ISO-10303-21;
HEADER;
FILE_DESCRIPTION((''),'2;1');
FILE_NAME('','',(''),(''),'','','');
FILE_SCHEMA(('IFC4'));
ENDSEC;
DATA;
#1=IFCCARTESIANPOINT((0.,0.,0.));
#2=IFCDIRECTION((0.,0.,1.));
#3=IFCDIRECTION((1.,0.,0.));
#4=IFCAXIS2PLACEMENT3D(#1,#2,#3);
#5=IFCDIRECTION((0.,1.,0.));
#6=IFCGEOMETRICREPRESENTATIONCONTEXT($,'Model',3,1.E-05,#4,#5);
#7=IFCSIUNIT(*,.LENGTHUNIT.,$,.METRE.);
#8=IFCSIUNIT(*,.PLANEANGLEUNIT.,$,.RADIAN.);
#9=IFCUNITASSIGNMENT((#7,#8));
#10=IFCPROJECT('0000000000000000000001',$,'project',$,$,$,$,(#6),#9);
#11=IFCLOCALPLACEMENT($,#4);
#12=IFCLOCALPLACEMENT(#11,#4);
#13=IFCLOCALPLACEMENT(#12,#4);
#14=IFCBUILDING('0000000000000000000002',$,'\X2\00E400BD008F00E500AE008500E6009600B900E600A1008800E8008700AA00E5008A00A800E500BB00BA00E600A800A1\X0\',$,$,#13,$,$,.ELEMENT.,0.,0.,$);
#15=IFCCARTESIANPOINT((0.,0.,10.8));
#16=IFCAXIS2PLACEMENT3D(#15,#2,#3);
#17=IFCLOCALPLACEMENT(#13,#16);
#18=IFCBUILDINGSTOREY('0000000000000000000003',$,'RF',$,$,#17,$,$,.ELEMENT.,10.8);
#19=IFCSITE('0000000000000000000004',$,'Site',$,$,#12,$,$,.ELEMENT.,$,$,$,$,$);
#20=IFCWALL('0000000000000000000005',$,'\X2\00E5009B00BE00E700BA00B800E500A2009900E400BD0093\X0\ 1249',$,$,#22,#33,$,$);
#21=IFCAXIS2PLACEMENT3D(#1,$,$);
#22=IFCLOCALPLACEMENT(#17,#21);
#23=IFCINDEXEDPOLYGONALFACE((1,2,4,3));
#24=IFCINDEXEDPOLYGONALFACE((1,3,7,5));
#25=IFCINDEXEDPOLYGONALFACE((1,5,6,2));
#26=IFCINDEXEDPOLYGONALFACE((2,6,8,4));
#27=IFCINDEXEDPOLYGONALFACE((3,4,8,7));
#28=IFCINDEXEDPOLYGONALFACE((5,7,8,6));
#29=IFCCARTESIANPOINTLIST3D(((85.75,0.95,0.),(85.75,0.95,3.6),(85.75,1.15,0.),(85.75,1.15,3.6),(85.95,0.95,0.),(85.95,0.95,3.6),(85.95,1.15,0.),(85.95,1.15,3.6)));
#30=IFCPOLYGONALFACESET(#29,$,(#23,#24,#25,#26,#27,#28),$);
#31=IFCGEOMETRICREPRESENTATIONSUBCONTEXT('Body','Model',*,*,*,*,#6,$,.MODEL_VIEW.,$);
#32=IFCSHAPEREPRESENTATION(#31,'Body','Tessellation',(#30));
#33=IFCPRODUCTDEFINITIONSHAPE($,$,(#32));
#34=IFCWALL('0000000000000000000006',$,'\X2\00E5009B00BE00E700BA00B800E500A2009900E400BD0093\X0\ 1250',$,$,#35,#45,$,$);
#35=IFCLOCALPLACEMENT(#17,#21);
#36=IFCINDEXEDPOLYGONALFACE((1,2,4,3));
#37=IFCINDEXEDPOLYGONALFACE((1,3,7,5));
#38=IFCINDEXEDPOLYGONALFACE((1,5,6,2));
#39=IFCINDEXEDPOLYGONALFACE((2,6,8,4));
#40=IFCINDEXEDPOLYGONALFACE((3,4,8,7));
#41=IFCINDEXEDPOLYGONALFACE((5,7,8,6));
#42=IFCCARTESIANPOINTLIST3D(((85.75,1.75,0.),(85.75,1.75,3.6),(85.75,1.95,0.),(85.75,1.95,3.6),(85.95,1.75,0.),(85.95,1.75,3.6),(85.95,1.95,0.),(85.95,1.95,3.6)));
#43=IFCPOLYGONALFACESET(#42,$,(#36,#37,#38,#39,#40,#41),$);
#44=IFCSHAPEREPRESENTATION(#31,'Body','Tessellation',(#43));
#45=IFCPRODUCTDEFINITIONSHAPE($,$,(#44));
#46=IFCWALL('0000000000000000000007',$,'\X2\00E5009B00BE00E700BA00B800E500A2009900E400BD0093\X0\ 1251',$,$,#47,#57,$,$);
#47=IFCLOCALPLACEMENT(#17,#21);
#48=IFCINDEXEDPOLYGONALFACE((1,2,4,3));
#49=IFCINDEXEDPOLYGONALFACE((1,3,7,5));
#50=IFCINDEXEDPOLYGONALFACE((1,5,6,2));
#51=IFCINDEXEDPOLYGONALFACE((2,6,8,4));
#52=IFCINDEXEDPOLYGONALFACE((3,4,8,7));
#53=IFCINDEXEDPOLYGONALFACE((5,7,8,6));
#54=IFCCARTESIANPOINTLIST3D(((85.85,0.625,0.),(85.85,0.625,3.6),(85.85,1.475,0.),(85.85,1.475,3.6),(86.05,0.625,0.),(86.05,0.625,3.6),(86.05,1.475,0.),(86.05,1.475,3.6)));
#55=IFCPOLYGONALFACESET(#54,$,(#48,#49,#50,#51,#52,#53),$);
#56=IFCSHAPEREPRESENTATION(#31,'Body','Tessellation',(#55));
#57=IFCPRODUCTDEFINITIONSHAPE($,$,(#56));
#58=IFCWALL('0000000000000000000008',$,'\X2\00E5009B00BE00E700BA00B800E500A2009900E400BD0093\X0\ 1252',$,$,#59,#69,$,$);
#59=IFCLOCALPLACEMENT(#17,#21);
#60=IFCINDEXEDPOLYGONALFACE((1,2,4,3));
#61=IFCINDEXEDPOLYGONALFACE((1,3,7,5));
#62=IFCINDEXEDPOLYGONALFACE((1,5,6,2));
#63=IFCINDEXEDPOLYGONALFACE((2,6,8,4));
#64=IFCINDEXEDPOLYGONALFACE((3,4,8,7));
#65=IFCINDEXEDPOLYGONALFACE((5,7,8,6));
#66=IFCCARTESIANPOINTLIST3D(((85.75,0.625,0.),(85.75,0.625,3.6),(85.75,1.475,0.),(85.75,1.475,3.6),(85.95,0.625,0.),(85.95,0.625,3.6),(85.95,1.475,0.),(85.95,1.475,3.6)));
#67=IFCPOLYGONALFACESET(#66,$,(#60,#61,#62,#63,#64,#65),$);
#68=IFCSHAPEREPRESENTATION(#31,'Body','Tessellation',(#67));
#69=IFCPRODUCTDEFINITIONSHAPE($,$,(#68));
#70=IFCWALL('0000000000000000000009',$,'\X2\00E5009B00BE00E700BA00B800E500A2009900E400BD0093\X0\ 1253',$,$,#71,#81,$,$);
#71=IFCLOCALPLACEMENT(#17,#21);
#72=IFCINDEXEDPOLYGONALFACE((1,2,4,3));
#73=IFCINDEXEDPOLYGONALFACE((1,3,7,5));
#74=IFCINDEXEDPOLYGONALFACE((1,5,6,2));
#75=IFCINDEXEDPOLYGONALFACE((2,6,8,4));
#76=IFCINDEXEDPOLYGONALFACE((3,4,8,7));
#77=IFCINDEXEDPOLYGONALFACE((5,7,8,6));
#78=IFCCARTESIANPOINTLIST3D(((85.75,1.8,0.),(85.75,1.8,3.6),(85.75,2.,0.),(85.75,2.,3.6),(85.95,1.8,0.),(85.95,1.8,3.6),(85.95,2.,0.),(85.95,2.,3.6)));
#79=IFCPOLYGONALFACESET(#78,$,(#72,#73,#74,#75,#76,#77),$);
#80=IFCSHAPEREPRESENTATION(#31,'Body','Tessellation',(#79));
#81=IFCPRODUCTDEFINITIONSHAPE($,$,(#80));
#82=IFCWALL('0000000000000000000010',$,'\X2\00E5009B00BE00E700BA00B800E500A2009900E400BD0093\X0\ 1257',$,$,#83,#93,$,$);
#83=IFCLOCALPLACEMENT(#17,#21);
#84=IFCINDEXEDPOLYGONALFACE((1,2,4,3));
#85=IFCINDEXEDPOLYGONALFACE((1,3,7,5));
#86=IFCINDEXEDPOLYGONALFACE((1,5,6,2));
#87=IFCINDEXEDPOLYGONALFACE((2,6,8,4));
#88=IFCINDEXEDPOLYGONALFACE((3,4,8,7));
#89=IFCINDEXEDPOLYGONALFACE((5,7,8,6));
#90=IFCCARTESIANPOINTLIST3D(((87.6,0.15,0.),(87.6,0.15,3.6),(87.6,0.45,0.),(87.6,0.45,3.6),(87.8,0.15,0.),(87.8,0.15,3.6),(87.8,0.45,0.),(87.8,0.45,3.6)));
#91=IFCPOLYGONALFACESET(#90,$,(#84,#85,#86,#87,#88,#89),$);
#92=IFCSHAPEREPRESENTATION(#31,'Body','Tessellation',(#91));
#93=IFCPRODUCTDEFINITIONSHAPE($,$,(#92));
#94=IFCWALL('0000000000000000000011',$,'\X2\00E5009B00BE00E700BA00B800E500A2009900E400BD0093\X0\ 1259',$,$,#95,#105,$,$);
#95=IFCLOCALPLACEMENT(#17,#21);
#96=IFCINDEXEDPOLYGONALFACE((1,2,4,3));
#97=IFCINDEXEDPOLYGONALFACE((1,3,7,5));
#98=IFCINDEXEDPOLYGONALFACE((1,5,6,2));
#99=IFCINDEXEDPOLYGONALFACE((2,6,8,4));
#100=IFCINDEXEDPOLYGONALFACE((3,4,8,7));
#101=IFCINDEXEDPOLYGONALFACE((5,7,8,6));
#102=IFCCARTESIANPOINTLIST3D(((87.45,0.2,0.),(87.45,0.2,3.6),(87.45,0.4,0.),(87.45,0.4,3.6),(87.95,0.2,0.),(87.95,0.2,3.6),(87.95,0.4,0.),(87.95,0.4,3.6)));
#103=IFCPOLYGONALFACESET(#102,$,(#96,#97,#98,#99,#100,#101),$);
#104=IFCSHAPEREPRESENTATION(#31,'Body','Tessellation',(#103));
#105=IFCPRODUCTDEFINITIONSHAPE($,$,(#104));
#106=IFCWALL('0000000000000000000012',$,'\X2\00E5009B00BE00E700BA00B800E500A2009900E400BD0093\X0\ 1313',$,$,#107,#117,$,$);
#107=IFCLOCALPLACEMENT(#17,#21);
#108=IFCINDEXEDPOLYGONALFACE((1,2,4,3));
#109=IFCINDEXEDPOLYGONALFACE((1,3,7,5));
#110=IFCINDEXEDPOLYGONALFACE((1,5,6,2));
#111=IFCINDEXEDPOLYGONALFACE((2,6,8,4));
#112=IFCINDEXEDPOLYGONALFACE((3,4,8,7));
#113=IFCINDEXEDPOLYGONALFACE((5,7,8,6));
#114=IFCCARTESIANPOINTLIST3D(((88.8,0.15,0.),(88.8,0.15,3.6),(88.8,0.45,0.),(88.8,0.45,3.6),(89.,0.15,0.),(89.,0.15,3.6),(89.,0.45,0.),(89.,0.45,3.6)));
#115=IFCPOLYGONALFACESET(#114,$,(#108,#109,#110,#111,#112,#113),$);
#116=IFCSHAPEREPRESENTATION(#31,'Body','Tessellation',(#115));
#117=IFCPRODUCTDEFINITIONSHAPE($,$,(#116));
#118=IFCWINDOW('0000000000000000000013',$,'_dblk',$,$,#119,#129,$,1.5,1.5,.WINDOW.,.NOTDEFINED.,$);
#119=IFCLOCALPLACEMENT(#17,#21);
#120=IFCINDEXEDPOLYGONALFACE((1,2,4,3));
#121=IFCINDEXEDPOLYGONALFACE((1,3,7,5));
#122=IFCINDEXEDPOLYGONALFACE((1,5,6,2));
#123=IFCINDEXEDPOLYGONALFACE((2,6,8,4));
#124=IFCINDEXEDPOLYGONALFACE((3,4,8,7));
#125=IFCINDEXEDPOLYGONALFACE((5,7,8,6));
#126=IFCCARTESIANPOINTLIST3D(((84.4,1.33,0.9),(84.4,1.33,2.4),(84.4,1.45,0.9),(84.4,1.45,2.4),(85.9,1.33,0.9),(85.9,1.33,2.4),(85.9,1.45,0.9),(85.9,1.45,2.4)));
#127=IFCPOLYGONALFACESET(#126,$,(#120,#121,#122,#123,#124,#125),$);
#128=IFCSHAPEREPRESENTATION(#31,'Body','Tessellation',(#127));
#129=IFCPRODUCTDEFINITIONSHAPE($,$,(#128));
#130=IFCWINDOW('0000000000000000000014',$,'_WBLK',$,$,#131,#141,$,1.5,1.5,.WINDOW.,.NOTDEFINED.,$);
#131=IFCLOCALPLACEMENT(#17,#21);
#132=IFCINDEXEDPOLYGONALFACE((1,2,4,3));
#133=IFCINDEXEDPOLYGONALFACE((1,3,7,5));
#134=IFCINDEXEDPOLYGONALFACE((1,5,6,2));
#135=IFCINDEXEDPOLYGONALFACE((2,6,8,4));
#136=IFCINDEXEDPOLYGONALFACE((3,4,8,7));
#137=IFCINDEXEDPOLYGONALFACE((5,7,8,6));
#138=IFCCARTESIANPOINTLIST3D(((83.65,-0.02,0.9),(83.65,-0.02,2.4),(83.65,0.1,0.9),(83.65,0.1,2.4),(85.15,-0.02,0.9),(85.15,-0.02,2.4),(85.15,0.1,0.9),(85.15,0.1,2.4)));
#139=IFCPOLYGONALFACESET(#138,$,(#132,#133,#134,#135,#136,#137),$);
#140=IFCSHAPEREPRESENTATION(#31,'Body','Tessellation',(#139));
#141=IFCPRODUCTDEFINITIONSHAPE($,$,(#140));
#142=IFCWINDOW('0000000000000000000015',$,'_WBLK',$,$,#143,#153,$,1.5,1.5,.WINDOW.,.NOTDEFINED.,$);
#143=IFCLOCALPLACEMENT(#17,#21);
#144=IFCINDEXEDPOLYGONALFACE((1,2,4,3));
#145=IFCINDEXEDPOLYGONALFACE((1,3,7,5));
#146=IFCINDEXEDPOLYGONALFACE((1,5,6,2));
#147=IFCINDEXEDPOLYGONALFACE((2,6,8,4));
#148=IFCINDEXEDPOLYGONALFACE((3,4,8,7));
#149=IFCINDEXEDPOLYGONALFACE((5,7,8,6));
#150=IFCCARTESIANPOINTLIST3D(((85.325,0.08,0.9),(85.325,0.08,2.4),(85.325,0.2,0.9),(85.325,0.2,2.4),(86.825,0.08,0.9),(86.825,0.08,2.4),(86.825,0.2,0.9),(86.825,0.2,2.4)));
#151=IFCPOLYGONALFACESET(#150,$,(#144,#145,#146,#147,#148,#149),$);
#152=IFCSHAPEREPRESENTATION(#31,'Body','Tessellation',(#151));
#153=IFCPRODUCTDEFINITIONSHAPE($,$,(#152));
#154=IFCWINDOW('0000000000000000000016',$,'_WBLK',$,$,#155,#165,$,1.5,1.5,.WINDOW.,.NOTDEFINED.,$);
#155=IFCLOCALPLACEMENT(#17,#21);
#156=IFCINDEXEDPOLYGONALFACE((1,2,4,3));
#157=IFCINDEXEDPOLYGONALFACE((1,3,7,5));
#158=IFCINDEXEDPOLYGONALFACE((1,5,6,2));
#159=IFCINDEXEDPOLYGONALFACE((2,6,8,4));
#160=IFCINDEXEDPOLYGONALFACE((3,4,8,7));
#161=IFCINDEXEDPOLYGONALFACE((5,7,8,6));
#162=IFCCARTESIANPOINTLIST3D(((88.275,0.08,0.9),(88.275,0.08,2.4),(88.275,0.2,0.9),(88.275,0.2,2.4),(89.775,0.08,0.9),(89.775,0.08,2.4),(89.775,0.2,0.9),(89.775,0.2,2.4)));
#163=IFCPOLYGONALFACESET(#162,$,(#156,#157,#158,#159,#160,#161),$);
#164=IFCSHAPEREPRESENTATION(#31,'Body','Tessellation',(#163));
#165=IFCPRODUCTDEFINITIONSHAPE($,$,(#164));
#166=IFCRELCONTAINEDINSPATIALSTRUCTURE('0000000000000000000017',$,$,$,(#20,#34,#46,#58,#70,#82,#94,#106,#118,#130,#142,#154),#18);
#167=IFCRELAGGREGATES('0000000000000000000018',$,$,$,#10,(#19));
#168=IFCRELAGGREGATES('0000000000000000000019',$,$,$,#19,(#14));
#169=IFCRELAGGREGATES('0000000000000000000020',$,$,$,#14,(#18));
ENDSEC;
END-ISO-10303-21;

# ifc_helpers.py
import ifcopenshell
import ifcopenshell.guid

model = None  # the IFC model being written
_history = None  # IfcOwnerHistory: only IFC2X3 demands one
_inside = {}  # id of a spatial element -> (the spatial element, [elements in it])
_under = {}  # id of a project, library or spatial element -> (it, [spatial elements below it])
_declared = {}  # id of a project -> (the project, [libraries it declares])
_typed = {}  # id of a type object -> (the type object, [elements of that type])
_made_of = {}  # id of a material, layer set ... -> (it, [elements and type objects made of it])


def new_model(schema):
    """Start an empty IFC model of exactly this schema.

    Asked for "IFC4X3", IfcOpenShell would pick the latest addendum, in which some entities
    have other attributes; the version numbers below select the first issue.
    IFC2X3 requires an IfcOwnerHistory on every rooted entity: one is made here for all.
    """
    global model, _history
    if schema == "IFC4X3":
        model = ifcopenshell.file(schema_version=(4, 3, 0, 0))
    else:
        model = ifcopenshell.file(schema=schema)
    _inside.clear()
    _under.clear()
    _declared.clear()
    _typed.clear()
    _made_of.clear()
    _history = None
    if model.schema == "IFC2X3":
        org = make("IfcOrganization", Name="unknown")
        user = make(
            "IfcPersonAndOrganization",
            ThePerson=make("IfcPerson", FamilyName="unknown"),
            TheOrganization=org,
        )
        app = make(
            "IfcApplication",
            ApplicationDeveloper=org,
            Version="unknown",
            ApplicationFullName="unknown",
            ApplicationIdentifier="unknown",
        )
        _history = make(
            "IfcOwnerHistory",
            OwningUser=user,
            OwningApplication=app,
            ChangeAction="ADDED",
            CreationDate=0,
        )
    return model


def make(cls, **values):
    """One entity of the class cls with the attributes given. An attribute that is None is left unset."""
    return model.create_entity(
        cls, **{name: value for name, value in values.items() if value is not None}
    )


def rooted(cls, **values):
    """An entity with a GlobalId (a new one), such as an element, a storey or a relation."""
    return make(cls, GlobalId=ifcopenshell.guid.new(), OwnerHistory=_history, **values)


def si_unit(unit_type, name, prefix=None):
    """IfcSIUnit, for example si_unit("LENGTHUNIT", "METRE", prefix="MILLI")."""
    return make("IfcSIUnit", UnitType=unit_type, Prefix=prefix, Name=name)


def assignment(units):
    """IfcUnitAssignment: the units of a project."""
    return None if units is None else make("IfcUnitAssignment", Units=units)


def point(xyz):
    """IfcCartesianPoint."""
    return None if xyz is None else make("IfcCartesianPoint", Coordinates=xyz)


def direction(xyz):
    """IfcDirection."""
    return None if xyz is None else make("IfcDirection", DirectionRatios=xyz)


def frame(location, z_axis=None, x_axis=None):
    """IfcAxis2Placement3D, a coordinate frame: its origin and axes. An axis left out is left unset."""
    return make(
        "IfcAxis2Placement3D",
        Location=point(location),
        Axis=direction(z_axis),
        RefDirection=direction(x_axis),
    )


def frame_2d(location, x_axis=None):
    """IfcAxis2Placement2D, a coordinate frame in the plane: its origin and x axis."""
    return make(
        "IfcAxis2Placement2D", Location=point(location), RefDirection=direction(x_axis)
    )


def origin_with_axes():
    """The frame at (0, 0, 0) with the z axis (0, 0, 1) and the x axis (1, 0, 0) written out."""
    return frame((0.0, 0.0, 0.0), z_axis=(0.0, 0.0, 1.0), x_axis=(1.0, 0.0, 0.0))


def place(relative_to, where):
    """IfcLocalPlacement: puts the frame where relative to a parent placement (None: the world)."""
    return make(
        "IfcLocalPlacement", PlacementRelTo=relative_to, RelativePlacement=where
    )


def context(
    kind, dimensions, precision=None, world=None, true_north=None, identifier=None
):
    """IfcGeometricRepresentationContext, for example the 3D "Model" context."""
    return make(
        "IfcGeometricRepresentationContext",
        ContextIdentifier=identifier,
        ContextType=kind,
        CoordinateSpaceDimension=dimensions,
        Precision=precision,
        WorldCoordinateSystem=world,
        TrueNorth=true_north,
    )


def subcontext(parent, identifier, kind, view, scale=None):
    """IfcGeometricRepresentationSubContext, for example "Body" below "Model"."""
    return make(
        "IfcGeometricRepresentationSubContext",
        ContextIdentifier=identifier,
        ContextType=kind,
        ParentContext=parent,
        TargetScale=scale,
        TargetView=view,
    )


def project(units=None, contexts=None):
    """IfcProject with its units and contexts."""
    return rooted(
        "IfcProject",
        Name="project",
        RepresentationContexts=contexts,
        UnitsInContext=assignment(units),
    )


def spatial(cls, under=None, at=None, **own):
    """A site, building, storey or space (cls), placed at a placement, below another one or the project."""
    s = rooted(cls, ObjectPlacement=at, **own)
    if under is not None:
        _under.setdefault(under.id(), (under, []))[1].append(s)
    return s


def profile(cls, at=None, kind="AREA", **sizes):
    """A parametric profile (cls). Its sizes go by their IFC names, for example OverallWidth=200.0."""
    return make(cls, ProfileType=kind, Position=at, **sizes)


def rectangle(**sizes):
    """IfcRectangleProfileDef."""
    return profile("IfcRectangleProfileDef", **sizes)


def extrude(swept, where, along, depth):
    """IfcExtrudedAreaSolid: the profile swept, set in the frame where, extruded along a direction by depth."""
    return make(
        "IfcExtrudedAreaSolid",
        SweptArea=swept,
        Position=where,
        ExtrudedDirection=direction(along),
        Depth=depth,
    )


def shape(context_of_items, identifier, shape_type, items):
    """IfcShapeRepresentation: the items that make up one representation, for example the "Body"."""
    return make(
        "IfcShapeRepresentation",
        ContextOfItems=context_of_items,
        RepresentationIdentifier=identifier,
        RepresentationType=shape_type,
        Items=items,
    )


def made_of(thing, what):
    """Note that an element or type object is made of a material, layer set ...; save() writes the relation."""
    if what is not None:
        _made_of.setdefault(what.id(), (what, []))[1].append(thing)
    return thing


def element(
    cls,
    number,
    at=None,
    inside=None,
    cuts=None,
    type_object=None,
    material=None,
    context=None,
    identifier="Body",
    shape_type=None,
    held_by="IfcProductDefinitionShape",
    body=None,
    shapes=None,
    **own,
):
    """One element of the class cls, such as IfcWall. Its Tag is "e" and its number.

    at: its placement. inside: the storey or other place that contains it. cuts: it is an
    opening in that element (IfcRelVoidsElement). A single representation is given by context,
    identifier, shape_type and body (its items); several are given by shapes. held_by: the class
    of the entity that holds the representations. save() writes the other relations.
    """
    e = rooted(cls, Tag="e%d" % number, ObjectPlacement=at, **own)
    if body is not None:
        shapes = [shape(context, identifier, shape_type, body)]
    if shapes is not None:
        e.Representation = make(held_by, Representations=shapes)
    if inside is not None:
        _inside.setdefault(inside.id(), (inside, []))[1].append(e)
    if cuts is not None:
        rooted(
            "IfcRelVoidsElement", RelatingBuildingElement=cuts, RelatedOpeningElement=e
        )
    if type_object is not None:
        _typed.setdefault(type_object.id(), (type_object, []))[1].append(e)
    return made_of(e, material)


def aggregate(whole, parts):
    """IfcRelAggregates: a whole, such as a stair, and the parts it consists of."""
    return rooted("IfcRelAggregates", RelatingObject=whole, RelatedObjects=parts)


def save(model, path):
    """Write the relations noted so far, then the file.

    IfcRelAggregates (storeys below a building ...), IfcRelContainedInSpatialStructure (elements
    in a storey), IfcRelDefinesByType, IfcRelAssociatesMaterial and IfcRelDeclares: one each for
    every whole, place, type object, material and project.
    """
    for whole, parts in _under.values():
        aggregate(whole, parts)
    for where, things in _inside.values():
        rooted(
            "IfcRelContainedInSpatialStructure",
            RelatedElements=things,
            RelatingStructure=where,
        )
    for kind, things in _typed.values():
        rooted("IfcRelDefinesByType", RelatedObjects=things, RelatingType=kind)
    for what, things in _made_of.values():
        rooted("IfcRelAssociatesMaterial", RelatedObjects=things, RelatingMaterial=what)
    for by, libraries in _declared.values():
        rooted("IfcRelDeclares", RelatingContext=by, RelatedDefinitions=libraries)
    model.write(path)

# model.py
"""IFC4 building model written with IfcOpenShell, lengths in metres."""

from ifc_helpers import new_model, si_unit, direction, frame, frame_2d, origin_with_axes, place, context, subcontext, project, spatial, rectangle, extrude, element, save


model = new_model("IFC4")

# Units and contexts
model_context = context("Model", 3, precision=1e-05, world=origin_with_axes(), true_north=direction((0.0, 1.0, 0.0)))
body_context = subcontext(model_context, "Body", "Model", "MODEL_VIEW")
ifc_project = project(units=[si_unit("LENGTHUNIT", "METRE"), si_unit("PLANEANGLEUNIT", "RADIAN")], contexts=[model_context])

# Site, building, storey
placement = place(None, origin_with_axes())
site_placement = place(placement, origin_with_axes())
site = spatial("IfcSite", under=ifc_project, at=site_placement, Name="Site", CompositionType="ELEMENT")
building_placement = place(site_placement, origin_with_axes())
building = spatial("IfcBuilding", under=site, at=building_placement, Name="ä½\u008få®\u0085æ\u0096¹æ¡\u0088è\u0087ªå\u008a¨å»ºæ¨¡", CompositionType="ELEMENT", ElevationOfRefHeight=0.0, ElevationOfTerrain=0.0)
storey_placement = place(building_placement, frame((0.0, 0.0, 10.8), z_axis=(0.0, 0.0, 1.0), x_axis=(1.0, 0.0, 0.0)))
storey = spatial("IfcBuildingStorey", under=building, at=storey_placement, Name="RF", CompositionType="ELEMENT", Elevation=10.8)

# Walls
for number, where, z_axis, x_axis, name in (
    (1, (85.85, 1.05, 0.0), (0.0, 0.0, 1.0), (1.0, 0.0, 0.0), "å\u009b¾çº¸å¢\u0099ä½\u0093 1249"),
    (2, (85.85, 1.85, 0.0), (0.0, 0.0, 1.0), (1.0, 0.0, 0.0), "å\u009b¾çº¸å¢\u0099ä½\u0093 1250"),
):
    element("IfcWall", number, at=place(storey_placement, frame(where, z_axis=z_axis, x_axis=x_axis)), inside=storey, Name=name, context=body_context, shape_type="SweptSolid", body=[
        extrude(rectangle(XDim=0.2, YDim=0.2, at=frame_2d((0.0, 0.0), x_axis=(1.0, 0.0, 0.0))), frame((0.0, 0.0, 0.0), z_axis=(0.0, 0.0, 1.0)), (0.0, 0.0, 1.0), 3.6),
    ])
for number, where, z_axis, x_axis, name in (
    (3, (85.95, 1.05, 0.0), (0.0, 0.0, 1.0), (0.0, -1.0, 0.0), "å\u009b¾çº¸å¢\u0099ä½\u0093 1251"),
    (4, (85.85, 1.05, 0.0), (0.0, 0.0, 1.0), (0.0, -1.0, 0.0), "å\u009b¾çº¸å¢\u0099ä½\u0093 1252"),
):
    element("IfcWall", number, at=place(storey_placement, frame(where, z_axis=z_axis, x_axis=x_axis)), inside=storey, Name=name, context=body_context, shape_type="SweptSolid", body=[
        extrude(rectangle(XDim=0.85, YDim=0.2, at=frame_2d((0.0, 0.0), x_axis=(1.0, 0.0, 0.0))), frame((0.0, 0.0, 0.0), z_axis=(0.0, 0.0, 1.0)), (0.0, 0.0, 1.0), 3.6),
    ])
wall_1_placement = place(storey_placement, frame((85.85, 1.9, 0.0), z_axis=(0.0, 0.0, 1.0), x_axis=(0.0, -1.0, 0.0)))
element("IfcWall", 5, at=wall_1_placement, inside=storey, Name="å\u009b¾çº¸å¢\u0099ä½\u0093 1253", context=body_context, shape_type="SweptSolid", body=[
    extrude(rectangle(XDim=0.2, YDim=0.2, at=frame_2d((0.0, 0.0), x_axis=(1.0, 0.0, 0.0))), frame((0.0, 0.0, 0.0), z_axis=(0.0, 0.0, 1.0)), (0.0, 0.0, 1.0), 3.6),
])
wall_2_placement = place(storey_placement, frame((87.7, 0.3, 0.0), z_axis=(0.0, 0.0, 1.0), x_axis=(0.0, -1.0, 0.0)))
element("IfcWall", 6, at=wall_2_placement, inside=storey, Name="å\u009b¾çº¸å¢\u0099ä½\u0093 1257", context=body_context, shape_type="SweptSolid", body=[
    extrude(rectangle(XDim=0.3, YDim=0.2, at=frame_2d((0.0, 0.0), x_axis=(1.0, 0.0, 0.0))), frame((0.0, 0.0, 0.0), z_axis=(0.0, 0.0, 1.0)), (0.0, 0.0, 1.0), 3.6),
])
wall_3_placement = place(storey_placement, frame((87.7, 0.3, 0.0), z_axis=(0.0, 0.0, 1.0), x_axis=(1.0, 0.0, 0.0)))
element("IfcWall", 7, at=wall_3_placement, inside=storey, Name="å\u009b¾çº¸å¢\u0099ä½\u0093 1259", context=body_context, shape_type="SweptSolid", body=[
    extrude(rectangle(XDim=0.5, YDim=0.2, at=frame_2d((0.0, 0.0), x_axis=(1.0, 0.0, 0.0))), frame((0.0, 0.0, 0.0), z_axis=(0.0, 0.0, 1.0)), (0.0, 0.0, 1.0), 3.6),
])
wall_4_placement = place(storey_placement, frame((88.9, 0.3, 0.0), z_axis=(0.0, 0.0, 1.0), x_axis=(0.0, -1.0, 0.0)))
element("IfcWall", 8, at=wall_4_placement, inside=storey, Name="å\u009b¾çº¸å¢\u0099ä½\u0093 1313", context=body_context, shape_type="SweptSolid", body=[
    extrude(rectangle(XDim=0.3, YDim=0.2, at=frame_2d((0.0, 0.0), x_axis=(1.0, 0.0, 0.0))), frame((0.0, 0.0, 0.0), z_axis=(0.0, 0.0, 1.0)), (0.0, 0.0, 1.0), 3.6),
])

# Windows
for number, where, z_axis, x_axis, name in (
    (9, (85.15, 1.39, 0.9), (0.0, 0.0, 1.0), (1.0, 0.0, 0.0), "_dblk"),
    (10, (84.4, 0.04, 0.9), (0.0, 0.0, 1.0), (1.0, 0.0, 0.0), "_WBLK"),
    (11, (86.075, 0.14, 0.9), (0.0, 0.0, 1.0), (1.0, 0.0, 0.0), "_WBLK"),
    (12, (89.025, 0.14, 0.9), (0.0, 0.0, 1.0), (1.0, 0.0, 0.0), "_WBLK"),
):
    element("IfcWindow", number, at=place(storey_placement, frame(where, z_axis=z_axis, x_axis=x_axis)), inside=storey, Name=name, OverallHeight=1.5, OverallWidth=1.5, PartitioningType="NOTDEFINED", PredefinedType="WINDOW", context=body_context, shape_type="SweptSolid", body=[
        extrude(rectangle(XDim=1.5, YDim=0.12, at=frame_2d((0.0, 0.0), x_axis=(1.0, 0.0, 0.0))), frame((0.0, 0.0, 0.0), z_axis=(0.0, 0.0, 1.0)), (0.0, 0.0, 1.0), 1.5),
    ])

save(model, "model.ifc")
